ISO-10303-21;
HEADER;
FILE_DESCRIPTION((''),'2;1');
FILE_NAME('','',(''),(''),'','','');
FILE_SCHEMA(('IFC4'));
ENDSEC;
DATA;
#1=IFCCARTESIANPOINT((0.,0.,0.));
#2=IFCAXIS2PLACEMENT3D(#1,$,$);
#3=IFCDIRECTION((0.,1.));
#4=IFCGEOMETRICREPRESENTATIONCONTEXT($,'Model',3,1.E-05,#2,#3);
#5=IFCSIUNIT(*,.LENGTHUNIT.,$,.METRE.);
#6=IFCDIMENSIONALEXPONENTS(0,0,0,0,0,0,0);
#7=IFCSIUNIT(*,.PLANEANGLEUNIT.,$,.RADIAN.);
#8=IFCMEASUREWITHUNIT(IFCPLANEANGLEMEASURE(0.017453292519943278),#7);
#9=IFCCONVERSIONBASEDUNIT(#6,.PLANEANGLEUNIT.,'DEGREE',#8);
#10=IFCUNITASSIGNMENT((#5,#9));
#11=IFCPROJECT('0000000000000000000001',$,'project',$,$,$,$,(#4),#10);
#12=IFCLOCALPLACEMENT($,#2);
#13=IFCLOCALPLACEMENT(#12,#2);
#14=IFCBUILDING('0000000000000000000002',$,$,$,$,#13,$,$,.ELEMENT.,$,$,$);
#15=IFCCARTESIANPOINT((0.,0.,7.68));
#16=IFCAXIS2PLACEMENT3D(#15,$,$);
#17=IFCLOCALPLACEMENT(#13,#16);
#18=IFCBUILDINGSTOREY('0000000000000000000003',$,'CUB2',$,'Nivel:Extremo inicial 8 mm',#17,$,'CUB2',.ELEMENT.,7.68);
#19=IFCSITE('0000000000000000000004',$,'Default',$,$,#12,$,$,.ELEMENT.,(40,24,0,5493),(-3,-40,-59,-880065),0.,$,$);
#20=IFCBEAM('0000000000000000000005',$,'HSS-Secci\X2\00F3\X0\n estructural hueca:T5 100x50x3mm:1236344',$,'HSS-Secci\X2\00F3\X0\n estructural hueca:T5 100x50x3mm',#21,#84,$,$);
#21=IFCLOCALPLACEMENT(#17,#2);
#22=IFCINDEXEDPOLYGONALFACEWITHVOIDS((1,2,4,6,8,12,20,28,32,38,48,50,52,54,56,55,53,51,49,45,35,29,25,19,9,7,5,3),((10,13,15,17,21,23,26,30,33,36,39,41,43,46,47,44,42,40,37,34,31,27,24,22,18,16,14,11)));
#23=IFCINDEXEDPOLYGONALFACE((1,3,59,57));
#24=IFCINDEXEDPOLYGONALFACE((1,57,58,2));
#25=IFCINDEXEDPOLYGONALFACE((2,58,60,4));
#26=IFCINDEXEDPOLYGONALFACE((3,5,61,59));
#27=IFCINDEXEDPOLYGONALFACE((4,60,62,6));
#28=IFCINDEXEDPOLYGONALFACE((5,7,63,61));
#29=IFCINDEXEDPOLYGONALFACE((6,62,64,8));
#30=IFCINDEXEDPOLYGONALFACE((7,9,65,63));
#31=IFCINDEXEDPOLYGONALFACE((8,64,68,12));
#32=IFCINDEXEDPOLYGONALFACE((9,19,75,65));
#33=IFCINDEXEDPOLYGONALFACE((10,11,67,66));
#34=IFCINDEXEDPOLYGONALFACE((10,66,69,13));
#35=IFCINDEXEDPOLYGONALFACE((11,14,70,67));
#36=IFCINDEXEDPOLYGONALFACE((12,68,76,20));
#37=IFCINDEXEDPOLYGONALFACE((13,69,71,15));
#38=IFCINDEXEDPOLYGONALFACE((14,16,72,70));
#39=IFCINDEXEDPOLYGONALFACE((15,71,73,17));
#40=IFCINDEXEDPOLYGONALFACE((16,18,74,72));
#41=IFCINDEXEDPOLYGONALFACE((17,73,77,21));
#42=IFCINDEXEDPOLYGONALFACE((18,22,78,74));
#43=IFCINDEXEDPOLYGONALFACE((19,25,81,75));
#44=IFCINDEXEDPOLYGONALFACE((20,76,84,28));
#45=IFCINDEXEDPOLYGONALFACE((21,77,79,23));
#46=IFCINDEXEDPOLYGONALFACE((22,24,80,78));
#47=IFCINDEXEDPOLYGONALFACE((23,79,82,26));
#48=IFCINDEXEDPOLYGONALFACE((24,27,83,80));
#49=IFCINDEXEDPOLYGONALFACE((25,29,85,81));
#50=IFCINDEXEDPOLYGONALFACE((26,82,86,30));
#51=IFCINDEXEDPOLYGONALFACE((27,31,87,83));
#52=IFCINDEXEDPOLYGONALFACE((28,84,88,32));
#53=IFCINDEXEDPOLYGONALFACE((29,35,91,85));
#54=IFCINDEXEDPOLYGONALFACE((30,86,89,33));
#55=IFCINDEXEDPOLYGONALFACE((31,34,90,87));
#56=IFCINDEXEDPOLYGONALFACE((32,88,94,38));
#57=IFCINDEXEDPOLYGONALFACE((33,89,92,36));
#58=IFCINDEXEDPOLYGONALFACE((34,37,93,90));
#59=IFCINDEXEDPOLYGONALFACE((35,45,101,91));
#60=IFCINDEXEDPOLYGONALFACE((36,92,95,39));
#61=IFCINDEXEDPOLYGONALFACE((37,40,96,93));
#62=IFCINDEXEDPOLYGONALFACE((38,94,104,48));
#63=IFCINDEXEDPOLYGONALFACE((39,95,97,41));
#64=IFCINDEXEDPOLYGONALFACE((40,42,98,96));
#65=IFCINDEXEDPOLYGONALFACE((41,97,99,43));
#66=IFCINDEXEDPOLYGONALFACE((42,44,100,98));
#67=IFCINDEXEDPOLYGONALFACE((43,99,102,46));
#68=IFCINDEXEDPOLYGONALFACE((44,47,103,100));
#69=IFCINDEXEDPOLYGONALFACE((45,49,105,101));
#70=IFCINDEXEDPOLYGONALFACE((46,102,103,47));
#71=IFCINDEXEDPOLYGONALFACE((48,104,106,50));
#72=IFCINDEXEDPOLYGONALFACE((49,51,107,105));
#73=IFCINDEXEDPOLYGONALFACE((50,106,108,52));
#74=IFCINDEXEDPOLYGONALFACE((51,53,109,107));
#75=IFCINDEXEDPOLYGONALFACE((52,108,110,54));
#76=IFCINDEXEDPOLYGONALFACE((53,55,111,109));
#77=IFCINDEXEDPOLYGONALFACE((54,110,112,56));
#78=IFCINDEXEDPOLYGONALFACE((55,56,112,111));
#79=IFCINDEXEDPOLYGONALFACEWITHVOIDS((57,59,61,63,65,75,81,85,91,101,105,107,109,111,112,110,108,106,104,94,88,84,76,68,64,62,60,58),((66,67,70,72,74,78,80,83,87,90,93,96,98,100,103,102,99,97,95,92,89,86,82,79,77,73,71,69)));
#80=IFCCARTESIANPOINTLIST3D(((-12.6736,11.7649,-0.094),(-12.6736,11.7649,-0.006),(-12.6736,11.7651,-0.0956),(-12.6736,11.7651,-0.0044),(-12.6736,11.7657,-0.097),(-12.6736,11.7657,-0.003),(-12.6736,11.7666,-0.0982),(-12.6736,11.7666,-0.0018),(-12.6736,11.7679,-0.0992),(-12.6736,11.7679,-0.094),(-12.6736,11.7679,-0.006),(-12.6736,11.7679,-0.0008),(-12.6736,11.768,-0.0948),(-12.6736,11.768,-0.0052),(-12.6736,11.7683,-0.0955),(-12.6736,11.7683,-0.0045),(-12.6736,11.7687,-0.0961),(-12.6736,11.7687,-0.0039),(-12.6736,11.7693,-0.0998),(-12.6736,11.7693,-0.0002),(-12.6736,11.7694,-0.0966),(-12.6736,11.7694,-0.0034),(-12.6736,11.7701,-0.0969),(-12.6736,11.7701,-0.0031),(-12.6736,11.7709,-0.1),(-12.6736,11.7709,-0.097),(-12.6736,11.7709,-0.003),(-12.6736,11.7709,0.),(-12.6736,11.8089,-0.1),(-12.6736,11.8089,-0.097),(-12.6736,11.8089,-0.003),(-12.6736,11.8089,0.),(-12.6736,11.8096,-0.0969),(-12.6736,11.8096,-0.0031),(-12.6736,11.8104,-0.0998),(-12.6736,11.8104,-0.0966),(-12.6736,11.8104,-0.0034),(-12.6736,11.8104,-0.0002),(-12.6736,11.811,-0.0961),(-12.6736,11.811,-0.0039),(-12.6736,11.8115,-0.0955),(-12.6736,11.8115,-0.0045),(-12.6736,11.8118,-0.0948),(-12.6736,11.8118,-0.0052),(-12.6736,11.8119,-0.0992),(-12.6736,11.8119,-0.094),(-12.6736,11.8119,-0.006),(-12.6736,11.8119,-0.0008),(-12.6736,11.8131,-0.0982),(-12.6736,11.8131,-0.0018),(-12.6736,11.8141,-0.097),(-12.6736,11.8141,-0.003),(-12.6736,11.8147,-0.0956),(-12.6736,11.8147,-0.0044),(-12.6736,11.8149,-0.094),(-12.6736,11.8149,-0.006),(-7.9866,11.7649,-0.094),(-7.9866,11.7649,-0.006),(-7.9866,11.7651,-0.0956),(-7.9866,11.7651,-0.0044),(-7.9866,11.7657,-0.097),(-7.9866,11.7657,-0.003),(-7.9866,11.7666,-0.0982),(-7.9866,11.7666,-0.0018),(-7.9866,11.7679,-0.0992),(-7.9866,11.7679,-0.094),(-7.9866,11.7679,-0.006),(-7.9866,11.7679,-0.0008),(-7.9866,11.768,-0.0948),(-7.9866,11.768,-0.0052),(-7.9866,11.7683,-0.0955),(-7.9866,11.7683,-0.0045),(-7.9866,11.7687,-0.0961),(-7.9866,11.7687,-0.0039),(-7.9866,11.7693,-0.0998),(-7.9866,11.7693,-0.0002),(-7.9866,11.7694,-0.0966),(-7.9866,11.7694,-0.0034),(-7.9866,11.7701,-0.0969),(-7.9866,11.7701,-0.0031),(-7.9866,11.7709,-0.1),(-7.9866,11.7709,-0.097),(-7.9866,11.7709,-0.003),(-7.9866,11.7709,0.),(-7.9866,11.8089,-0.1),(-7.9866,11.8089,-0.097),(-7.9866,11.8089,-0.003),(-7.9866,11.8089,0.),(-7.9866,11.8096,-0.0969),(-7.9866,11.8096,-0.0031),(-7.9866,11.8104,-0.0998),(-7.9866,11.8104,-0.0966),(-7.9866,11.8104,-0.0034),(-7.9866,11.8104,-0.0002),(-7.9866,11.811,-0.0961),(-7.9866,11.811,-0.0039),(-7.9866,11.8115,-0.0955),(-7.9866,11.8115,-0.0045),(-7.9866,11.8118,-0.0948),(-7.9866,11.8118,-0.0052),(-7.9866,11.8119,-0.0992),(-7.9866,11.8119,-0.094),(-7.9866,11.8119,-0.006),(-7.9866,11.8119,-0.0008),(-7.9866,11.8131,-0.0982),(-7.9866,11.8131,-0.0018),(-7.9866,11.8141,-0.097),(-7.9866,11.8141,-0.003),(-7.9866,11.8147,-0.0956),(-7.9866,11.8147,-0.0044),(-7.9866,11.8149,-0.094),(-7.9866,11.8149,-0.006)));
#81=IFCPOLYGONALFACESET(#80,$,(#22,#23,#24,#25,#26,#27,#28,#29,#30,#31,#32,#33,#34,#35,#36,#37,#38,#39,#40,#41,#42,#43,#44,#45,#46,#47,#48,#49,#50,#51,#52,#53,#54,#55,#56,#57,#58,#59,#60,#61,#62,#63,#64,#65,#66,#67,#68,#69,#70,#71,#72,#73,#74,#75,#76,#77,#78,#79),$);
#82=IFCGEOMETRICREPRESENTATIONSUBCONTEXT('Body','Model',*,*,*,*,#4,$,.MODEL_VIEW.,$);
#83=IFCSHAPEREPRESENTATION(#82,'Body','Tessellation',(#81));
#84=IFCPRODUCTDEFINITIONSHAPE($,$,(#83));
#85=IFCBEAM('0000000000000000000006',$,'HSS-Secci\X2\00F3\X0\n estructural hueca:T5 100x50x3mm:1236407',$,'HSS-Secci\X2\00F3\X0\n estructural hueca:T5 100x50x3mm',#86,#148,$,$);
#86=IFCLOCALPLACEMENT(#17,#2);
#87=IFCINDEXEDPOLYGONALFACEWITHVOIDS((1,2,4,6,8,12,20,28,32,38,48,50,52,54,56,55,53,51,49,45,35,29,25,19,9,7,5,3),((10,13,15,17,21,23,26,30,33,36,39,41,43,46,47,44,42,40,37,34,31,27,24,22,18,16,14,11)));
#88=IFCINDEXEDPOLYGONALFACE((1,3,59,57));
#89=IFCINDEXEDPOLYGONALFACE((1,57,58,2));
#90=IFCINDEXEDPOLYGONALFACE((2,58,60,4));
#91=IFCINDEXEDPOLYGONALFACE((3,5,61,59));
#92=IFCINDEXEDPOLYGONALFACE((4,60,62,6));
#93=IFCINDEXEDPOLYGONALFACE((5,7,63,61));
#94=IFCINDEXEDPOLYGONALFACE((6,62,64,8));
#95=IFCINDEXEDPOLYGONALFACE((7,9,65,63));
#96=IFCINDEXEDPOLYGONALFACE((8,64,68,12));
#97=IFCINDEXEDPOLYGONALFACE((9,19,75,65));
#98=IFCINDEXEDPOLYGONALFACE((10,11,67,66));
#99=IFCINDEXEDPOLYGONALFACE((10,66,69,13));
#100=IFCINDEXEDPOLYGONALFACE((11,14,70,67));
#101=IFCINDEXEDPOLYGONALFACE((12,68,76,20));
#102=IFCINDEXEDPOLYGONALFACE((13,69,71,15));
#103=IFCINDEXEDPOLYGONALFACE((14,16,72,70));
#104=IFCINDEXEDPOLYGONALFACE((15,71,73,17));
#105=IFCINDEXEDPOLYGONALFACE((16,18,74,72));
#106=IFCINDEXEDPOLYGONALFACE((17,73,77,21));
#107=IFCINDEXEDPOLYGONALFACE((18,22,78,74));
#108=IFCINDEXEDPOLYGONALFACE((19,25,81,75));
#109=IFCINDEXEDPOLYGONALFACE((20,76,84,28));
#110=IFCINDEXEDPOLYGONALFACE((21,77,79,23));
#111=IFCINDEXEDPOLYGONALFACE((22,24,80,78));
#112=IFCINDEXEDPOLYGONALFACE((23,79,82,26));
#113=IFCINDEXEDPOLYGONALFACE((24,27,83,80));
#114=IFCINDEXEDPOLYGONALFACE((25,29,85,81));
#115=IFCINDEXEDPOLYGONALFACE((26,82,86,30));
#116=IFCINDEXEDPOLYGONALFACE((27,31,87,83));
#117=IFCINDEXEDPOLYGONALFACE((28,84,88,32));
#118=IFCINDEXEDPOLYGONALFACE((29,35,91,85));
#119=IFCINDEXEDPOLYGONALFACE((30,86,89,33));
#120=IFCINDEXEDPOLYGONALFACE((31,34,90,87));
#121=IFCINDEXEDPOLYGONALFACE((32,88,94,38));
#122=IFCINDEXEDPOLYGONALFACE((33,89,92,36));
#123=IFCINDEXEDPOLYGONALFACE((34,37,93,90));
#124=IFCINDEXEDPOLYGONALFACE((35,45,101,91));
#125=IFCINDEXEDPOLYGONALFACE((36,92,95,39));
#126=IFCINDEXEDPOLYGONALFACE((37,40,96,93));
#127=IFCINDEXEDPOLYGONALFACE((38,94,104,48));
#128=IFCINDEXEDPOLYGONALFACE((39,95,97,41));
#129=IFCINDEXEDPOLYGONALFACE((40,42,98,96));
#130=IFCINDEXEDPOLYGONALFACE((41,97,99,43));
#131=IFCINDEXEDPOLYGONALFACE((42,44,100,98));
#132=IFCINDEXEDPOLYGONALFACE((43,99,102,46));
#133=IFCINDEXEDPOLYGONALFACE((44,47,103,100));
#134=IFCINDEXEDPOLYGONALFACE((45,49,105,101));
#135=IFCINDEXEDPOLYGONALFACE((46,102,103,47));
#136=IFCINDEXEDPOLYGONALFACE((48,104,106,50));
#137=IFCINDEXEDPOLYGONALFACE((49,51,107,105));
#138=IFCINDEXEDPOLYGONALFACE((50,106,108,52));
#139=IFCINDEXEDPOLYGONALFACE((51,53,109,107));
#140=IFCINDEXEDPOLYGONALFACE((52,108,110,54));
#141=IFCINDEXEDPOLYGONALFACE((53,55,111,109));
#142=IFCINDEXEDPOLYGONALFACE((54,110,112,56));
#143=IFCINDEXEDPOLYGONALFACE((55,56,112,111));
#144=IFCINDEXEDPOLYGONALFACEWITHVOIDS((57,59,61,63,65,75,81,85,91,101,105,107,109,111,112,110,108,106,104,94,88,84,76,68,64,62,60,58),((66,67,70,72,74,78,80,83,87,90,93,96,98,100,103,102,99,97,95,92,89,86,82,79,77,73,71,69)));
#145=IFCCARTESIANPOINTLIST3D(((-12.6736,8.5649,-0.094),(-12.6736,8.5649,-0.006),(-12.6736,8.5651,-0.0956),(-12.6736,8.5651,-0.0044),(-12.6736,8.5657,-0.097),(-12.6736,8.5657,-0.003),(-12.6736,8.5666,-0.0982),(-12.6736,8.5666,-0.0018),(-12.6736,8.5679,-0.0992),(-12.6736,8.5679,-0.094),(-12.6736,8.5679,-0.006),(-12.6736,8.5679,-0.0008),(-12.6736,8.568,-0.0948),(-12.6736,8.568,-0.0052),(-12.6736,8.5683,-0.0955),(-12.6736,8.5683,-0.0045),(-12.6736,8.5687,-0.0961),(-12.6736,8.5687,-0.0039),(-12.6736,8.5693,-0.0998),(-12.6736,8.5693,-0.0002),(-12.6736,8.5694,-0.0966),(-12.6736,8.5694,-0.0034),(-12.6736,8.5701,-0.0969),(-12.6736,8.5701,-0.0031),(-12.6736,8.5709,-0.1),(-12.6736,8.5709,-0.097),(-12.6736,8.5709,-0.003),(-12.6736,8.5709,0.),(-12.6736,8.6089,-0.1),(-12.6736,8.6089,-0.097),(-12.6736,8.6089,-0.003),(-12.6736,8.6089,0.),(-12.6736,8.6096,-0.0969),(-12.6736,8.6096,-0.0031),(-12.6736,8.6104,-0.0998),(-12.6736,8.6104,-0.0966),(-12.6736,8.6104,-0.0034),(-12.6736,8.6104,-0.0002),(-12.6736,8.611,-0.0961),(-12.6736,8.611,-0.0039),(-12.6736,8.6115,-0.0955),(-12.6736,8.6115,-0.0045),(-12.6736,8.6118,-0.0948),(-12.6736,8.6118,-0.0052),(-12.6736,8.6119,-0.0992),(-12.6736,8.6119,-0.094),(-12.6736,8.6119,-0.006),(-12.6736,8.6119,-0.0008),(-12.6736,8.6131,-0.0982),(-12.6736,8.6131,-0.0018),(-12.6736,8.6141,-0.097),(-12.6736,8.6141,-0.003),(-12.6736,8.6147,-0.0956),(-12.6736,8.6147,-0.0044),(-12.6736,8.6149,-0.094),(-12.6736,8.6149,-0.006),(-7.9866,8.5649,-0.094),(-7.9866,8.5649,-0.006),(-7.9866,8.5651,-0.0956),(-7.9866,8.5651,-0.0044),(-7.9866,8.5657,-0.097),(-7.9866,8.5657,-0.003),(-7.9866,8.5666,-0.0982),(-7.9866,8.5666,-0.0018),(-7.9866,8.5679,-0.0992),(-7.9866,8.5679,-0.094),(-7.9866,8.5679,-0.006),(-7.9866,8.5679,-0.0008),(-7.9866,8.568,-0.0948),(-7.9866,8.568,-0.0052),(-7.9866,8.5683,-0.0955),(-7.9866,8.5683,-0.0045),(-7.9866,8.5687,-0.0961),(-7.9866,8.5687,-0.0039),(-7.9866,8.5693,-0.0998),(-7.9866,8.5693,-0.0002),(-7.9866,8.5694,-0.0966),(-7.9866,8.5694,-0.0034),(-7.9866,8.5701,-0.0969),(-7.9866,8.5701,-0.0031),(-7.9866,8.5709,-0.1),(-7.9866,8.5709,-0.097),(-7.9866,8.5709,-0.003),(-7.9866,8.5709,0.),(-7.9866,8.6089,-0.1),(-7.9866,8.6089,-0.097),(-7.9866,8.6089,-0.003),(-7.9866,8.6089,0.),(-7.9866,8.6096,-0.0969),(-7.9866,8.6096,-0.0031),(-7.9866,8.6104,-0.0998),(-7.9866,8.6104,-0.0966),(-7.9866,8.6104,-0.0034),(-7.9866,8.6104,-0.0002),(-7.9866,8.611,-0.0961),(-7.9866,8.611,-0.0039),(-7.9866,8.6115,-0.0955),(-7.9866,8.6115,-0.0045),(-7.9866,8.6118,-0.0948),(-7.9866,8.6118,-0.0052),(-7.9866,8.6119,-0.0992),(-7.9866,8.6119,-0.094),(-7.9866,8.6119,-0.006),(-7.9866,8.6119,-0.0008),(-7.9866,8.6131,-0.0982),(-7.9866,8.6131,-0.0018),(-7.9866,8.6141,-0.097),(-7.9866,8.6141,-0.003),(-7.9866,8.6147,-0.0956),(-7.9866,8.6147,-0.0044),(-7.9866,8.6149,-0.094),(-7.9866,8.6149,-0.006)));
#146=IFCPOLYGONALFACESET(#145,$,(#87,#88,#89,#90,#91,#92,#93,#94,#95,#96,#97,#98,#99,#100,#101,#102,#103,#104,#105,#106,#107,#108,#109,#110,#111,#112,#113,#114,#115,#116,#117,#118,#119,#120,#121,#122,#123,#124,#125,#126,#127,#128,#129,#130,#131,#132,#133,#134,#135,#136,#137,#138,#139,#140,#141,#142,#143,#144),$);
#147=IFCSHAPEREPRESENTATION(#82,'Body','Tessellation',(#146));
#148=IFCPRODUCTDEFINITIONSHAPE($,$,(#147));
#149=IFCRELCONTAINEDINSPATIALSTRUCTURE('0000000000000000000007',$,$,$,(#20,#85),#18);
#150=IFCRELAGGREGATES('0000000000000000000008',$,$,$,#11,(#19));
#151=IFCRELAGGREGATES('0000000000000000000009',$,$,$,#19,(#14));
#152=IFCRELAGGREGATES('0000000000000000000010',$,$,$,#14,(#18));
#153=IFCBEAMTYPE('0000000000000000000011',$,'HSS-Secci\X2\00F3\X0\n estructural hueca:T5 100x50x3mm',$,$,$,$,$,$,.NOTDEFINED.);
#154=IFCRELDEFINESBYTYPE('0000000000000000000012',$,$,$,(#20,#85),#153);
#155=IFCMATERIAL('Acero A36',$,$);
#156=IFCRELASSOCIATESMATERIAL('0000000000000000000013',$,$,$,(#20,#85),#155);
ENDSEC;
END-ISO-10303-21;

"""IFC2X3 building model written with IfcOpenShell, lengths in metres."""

from ifc_helpers import new_model, entity, si_unit, converted_unit, direction, frame, frame_2d, origin, place, context, subcontext, project, spatial, polyline, circle_curve, parameter, trimmed, segment, composite_curve, outline, extrude, material, type_object, element, save


model = new_model("IFC2X3")

# Units and contexts
model_context = context("Model", 3, precision=1e-05, world=origin(), true_north=direction((0.0, 1.0)))
body_context = subcontext(model_context, "Body", "Model", "MODEL_VIEW")
ifc_project = project(units=[si_unit("LENGTHUNIT", "METRE"), converted_unit("PLANEANGLEUNIT", "DEGREE", entity("IfcPlaneAngleMeasure", 0.017453292519943278), si_unit("PLANEANGLEUNIT", "RADIAN"), dimensions=[0, 0, 0, 0, 0, 0, 0])], contexts=[model_context])

# Site, building, storey
site_placement = place(None, origin())
site = spatial("IfcSite", under=ifc_project, at=site_placement, Name="Default", CompositionType="ELEMENT", RefLatitude=(40, 24, 0, 5493), RefLongitude=(-3, -40, -59, -880065), RefElevation=0.0)
building_placement = place(site_placement, origin())
building = spatial("IfcBuilding", under=site, at=building_placement, CompositionType="ELEMENT")
storey_placement = place(building_placement, frame((0.0, 0.0, 7.68)))
storey = spatial("IfcBuildingStorey", under=building, at=storey_placement, Name="CUB2", ObjectType="Nivel:Extremo inicial 8 mm", LongName="CUB2", CompositionType="ELEMENT", Elevation=7.68)

# Beams
ifc_material = material(Name="Acero A36")
beam_type_1 = type_object("IfcBeamType", Name="HSS-Sección estructural hueca:T5 100x50x3mm", PredefinedType="NOTDEFINED")
beam_1_placement = place(storey_placement, frame((-12.6736, 11.7899, 0.0)))
element("IfcBeam", 1, at=beam_1_placement, inside=storey, type_object=beam_type_1, material=ifc_material, Name="HSS-Sección estructural hueca:T5 100x50x3mm:1236344", ObjectType="HSS-Sección estructural hueca:T5 100x50x3mm", context=body_context, shape_type="SweptSolid", body=[
    extrude(outline(composite_curve([segment(trimmed(circle_curve(frame_2d((-0.019, -0.044), x_axis=(1.0, 0.0)), 0.006), [parameter(180.0)], [parameter(270.0)], True, "PARAMETER"), True, "CONTINUOUS"), segment(polyline([(-0.019, -0.05), (0.019, -0.05)]), True, "CONTINUOUS"), segment(trimmed(circle_curve(frame_2d((0.019, -0.044), x_axis=(1.0, 0.0)), 0.006), [parameter(270.0)], [parameter(0.0)], True, "PARAMETER"), True, "CONTINUOUS"), segment(polyline([(0.025, -0.044), (0.025, 0.044)]), True, "CONTINUOUS"), segment(trimmed(circle_curve(frame_2d((0.019, 0.044), x_axis=(1.0, 0.0)), 0.006), [parameter(360.0)], [parameter(90.0)], True, "PARAMETER"), True, "CONTINUOUS"), segment(polyline([(0.019, 0.05), (-0.019, 0.05)]), True, "CONTINUOUS"), segment(trimmed(circle_curve(frame_2d((-0.019, 0.044), x_axis=(1.0, 0.0)), 0.006), [parameter(90.0)], [parameter(180.0)], True, "PARAMETER"), True, "CONTINUOUS"), segment(polyline([(-0.025, 0.044), (-0.025, -0.044)]), True, "CONTINUOUS")], self_intersect=False), holes=[composite_curve([segment(polyline([(0.019, -0.047), (-0.019, -0.047)]), True, "CONTINUOUS"), segment(trimmed(circle_curve(frame_2d((-0.019, -0.044), x_axis=(1.0, 0.0)), 0.003), [parameter(180.0)], [parameter(270.0)], True, "PARAMETER"), False, "CONTINUOUS"), segment(polyline([(-0.022, -0.044), (-0.022, 0.044)]), True, "CONTINUOUS"), segment(trimmed(circle_curve(frame_2d((-0.019, 0.044), x_axis=(1.0, 0.0)), 0.003), [parameter(90.0)], [parameter(180.0)], True, "PARAMETER"), False, "CONTINUOUS"), segment(polyline([(-0.019, 0.047), (0.019, 0.047)]), True, "CONTINUOUS"), segment(trimmed(circle_curve(frame_2d((0.019, 0.044), x_axis=(1.0, 0.0)), 0.003), [parameter(0.0)], [parameter(90.0)], True, "PARAMETER"), False, "CONTINUOUS"), segment(polyline([(0.022, 0.044), (0.022, -0.044)]), True, "CONTINUOUS"), segment(trimmed(circle_curve(frame_2d((0.019, -0.044), x_axis=(1.0, 0.0)), 0.003), [parameter(270.0)], [parameter(0.0)], True, "PARAMETER"), False, "CONTINUOUS")], self_intersect=False)]), frame((0.0, 0.0, -0.05), z_axis=(1.0, 0.0, 0.0), x_axis=(0.0, -1.0, 0.0)), (0.0, 0.0, 1.0), 4.687),
])
beam_2_placement = place(storey_placement, frame((-7.8236, 8.5899, 0.0), z_axis=(0.0, 0.0, 1.0), x_axis=(-1.0, 0.0, 0.0)))
element("IfcBeam", 2, at=beam_2_placement, inside=storey, type_object=beam_type_1, material=ifc_material, Name="HSS-Sección estructural hueca:T5 100x50x3mm:1236407", ObjectType="HSS-Sección estructural hueca:T5 100x50x3mm", context=body_context, shape_type="SweptSolid", body=[
    extrude(outline(composite_curve([segment(trimmed(circle_curve(frame_2d((0.044, -0.019), x_axis=(1.0, 0.0)), 0.006), [parameter(270.0)], [parameter(360.0)], True, "PARAMETER"), True, "CONTINUOUS"), segment(polyline([(0.05, -0.019), (0.05, 0.019)]), True, "CONTINUOUS"), segment(trimmed(circle_curve(frame_2d((0.044, 0.019), x_axis=(0.0, 1.0)), 0.006), [parameter(270.0)], [parameter(0.0)], True, "PARAMETER"), True, "CONTINUOUS"), segment(polyline([(0.044, 0.025), (-0.044, 0.025)]), True, "CONTINUOUS"), segment(trimmed(circle_curve(frame_2d((-0.044, 0.019), x_axis=(-1.0, 0.0)), 0.006), [parameter(270.0)], [parameter(0.0)], True, "PARAMETER"), True, "CONTINUOUS"), segment(polyline([(-0.05, 0.019), (-0.05, -0.019)]), True, "CONTINUOUS"), segment(trimmed(circle_curve(frame_2d((-0.044, -0.019), x_axis=(0.0, -1.0)), 0.006), [parameter(270.0)], [parameter(0.0)], True, "PARAMETER"), True, "CONTINUOUS"), segment(polyline([(-0.044, -0.025), (0.044, -0.025)]), True, "CONTINUOUS")], self_intersect=False), holes=[composite_curve([segment(polyline([(0.047, 0.019), (0.047, -0.019)]), True, "CONTINUOUS"), segment(trimmed(circle_curve(frame_2d((0.044, -0.019), x_axis=(0.0, -1.0)), 0.003), [parameter(0.0)], [parameter(90.0)], True, "PARAMETER"), False, "CONTINUOUS"), segment(polyline([(0.044, -0.022), (-0.044, -0.022)]), True, "CONTINUOUS"), segment(trimmed(circle_curve(frame_2d((-0.044, -0.019), x_axis=(-1.0, 0.0)), 0.003), [parameter(0.0)], [parameter(90.0)], True, "PARAMETER"), False, "CONTINUOUS"), segment(polyline([(-0.047, -0.019), (-0.047, 0.019)]), True, "CONTINUOUS"), segment(trimmed(circle_curve(frame_2d((-0.044, 0.019), x_axis=(0.0, 1.0)), 0.003), [parameter(360.0)], [parameter(90.0)], True, "PARAMETER"), False, "CONTINUOUS"), segment(polyline([(-0.044, 0.022), (0.044, 0.022)]), True, "CONTINUOUS"), segment(trimmed(circle_curve(frame_2d((0.044, 0.019), x_axis=(1.0, 0.0)), 0.003), [parameter(360.0)], [parameter(90.0)], True, "PARAMETER"), False, "CONTINUOUS")], self_intersect=False)]), frame((0.163, 0.0, -0.05), z_axis=(1.0, 0.0, 0.0), x_axis=(0.0, 0.0, 1.0)), (0.0, 0.0, 1.0), 4.687),
])

save(model, "model.ifc")
